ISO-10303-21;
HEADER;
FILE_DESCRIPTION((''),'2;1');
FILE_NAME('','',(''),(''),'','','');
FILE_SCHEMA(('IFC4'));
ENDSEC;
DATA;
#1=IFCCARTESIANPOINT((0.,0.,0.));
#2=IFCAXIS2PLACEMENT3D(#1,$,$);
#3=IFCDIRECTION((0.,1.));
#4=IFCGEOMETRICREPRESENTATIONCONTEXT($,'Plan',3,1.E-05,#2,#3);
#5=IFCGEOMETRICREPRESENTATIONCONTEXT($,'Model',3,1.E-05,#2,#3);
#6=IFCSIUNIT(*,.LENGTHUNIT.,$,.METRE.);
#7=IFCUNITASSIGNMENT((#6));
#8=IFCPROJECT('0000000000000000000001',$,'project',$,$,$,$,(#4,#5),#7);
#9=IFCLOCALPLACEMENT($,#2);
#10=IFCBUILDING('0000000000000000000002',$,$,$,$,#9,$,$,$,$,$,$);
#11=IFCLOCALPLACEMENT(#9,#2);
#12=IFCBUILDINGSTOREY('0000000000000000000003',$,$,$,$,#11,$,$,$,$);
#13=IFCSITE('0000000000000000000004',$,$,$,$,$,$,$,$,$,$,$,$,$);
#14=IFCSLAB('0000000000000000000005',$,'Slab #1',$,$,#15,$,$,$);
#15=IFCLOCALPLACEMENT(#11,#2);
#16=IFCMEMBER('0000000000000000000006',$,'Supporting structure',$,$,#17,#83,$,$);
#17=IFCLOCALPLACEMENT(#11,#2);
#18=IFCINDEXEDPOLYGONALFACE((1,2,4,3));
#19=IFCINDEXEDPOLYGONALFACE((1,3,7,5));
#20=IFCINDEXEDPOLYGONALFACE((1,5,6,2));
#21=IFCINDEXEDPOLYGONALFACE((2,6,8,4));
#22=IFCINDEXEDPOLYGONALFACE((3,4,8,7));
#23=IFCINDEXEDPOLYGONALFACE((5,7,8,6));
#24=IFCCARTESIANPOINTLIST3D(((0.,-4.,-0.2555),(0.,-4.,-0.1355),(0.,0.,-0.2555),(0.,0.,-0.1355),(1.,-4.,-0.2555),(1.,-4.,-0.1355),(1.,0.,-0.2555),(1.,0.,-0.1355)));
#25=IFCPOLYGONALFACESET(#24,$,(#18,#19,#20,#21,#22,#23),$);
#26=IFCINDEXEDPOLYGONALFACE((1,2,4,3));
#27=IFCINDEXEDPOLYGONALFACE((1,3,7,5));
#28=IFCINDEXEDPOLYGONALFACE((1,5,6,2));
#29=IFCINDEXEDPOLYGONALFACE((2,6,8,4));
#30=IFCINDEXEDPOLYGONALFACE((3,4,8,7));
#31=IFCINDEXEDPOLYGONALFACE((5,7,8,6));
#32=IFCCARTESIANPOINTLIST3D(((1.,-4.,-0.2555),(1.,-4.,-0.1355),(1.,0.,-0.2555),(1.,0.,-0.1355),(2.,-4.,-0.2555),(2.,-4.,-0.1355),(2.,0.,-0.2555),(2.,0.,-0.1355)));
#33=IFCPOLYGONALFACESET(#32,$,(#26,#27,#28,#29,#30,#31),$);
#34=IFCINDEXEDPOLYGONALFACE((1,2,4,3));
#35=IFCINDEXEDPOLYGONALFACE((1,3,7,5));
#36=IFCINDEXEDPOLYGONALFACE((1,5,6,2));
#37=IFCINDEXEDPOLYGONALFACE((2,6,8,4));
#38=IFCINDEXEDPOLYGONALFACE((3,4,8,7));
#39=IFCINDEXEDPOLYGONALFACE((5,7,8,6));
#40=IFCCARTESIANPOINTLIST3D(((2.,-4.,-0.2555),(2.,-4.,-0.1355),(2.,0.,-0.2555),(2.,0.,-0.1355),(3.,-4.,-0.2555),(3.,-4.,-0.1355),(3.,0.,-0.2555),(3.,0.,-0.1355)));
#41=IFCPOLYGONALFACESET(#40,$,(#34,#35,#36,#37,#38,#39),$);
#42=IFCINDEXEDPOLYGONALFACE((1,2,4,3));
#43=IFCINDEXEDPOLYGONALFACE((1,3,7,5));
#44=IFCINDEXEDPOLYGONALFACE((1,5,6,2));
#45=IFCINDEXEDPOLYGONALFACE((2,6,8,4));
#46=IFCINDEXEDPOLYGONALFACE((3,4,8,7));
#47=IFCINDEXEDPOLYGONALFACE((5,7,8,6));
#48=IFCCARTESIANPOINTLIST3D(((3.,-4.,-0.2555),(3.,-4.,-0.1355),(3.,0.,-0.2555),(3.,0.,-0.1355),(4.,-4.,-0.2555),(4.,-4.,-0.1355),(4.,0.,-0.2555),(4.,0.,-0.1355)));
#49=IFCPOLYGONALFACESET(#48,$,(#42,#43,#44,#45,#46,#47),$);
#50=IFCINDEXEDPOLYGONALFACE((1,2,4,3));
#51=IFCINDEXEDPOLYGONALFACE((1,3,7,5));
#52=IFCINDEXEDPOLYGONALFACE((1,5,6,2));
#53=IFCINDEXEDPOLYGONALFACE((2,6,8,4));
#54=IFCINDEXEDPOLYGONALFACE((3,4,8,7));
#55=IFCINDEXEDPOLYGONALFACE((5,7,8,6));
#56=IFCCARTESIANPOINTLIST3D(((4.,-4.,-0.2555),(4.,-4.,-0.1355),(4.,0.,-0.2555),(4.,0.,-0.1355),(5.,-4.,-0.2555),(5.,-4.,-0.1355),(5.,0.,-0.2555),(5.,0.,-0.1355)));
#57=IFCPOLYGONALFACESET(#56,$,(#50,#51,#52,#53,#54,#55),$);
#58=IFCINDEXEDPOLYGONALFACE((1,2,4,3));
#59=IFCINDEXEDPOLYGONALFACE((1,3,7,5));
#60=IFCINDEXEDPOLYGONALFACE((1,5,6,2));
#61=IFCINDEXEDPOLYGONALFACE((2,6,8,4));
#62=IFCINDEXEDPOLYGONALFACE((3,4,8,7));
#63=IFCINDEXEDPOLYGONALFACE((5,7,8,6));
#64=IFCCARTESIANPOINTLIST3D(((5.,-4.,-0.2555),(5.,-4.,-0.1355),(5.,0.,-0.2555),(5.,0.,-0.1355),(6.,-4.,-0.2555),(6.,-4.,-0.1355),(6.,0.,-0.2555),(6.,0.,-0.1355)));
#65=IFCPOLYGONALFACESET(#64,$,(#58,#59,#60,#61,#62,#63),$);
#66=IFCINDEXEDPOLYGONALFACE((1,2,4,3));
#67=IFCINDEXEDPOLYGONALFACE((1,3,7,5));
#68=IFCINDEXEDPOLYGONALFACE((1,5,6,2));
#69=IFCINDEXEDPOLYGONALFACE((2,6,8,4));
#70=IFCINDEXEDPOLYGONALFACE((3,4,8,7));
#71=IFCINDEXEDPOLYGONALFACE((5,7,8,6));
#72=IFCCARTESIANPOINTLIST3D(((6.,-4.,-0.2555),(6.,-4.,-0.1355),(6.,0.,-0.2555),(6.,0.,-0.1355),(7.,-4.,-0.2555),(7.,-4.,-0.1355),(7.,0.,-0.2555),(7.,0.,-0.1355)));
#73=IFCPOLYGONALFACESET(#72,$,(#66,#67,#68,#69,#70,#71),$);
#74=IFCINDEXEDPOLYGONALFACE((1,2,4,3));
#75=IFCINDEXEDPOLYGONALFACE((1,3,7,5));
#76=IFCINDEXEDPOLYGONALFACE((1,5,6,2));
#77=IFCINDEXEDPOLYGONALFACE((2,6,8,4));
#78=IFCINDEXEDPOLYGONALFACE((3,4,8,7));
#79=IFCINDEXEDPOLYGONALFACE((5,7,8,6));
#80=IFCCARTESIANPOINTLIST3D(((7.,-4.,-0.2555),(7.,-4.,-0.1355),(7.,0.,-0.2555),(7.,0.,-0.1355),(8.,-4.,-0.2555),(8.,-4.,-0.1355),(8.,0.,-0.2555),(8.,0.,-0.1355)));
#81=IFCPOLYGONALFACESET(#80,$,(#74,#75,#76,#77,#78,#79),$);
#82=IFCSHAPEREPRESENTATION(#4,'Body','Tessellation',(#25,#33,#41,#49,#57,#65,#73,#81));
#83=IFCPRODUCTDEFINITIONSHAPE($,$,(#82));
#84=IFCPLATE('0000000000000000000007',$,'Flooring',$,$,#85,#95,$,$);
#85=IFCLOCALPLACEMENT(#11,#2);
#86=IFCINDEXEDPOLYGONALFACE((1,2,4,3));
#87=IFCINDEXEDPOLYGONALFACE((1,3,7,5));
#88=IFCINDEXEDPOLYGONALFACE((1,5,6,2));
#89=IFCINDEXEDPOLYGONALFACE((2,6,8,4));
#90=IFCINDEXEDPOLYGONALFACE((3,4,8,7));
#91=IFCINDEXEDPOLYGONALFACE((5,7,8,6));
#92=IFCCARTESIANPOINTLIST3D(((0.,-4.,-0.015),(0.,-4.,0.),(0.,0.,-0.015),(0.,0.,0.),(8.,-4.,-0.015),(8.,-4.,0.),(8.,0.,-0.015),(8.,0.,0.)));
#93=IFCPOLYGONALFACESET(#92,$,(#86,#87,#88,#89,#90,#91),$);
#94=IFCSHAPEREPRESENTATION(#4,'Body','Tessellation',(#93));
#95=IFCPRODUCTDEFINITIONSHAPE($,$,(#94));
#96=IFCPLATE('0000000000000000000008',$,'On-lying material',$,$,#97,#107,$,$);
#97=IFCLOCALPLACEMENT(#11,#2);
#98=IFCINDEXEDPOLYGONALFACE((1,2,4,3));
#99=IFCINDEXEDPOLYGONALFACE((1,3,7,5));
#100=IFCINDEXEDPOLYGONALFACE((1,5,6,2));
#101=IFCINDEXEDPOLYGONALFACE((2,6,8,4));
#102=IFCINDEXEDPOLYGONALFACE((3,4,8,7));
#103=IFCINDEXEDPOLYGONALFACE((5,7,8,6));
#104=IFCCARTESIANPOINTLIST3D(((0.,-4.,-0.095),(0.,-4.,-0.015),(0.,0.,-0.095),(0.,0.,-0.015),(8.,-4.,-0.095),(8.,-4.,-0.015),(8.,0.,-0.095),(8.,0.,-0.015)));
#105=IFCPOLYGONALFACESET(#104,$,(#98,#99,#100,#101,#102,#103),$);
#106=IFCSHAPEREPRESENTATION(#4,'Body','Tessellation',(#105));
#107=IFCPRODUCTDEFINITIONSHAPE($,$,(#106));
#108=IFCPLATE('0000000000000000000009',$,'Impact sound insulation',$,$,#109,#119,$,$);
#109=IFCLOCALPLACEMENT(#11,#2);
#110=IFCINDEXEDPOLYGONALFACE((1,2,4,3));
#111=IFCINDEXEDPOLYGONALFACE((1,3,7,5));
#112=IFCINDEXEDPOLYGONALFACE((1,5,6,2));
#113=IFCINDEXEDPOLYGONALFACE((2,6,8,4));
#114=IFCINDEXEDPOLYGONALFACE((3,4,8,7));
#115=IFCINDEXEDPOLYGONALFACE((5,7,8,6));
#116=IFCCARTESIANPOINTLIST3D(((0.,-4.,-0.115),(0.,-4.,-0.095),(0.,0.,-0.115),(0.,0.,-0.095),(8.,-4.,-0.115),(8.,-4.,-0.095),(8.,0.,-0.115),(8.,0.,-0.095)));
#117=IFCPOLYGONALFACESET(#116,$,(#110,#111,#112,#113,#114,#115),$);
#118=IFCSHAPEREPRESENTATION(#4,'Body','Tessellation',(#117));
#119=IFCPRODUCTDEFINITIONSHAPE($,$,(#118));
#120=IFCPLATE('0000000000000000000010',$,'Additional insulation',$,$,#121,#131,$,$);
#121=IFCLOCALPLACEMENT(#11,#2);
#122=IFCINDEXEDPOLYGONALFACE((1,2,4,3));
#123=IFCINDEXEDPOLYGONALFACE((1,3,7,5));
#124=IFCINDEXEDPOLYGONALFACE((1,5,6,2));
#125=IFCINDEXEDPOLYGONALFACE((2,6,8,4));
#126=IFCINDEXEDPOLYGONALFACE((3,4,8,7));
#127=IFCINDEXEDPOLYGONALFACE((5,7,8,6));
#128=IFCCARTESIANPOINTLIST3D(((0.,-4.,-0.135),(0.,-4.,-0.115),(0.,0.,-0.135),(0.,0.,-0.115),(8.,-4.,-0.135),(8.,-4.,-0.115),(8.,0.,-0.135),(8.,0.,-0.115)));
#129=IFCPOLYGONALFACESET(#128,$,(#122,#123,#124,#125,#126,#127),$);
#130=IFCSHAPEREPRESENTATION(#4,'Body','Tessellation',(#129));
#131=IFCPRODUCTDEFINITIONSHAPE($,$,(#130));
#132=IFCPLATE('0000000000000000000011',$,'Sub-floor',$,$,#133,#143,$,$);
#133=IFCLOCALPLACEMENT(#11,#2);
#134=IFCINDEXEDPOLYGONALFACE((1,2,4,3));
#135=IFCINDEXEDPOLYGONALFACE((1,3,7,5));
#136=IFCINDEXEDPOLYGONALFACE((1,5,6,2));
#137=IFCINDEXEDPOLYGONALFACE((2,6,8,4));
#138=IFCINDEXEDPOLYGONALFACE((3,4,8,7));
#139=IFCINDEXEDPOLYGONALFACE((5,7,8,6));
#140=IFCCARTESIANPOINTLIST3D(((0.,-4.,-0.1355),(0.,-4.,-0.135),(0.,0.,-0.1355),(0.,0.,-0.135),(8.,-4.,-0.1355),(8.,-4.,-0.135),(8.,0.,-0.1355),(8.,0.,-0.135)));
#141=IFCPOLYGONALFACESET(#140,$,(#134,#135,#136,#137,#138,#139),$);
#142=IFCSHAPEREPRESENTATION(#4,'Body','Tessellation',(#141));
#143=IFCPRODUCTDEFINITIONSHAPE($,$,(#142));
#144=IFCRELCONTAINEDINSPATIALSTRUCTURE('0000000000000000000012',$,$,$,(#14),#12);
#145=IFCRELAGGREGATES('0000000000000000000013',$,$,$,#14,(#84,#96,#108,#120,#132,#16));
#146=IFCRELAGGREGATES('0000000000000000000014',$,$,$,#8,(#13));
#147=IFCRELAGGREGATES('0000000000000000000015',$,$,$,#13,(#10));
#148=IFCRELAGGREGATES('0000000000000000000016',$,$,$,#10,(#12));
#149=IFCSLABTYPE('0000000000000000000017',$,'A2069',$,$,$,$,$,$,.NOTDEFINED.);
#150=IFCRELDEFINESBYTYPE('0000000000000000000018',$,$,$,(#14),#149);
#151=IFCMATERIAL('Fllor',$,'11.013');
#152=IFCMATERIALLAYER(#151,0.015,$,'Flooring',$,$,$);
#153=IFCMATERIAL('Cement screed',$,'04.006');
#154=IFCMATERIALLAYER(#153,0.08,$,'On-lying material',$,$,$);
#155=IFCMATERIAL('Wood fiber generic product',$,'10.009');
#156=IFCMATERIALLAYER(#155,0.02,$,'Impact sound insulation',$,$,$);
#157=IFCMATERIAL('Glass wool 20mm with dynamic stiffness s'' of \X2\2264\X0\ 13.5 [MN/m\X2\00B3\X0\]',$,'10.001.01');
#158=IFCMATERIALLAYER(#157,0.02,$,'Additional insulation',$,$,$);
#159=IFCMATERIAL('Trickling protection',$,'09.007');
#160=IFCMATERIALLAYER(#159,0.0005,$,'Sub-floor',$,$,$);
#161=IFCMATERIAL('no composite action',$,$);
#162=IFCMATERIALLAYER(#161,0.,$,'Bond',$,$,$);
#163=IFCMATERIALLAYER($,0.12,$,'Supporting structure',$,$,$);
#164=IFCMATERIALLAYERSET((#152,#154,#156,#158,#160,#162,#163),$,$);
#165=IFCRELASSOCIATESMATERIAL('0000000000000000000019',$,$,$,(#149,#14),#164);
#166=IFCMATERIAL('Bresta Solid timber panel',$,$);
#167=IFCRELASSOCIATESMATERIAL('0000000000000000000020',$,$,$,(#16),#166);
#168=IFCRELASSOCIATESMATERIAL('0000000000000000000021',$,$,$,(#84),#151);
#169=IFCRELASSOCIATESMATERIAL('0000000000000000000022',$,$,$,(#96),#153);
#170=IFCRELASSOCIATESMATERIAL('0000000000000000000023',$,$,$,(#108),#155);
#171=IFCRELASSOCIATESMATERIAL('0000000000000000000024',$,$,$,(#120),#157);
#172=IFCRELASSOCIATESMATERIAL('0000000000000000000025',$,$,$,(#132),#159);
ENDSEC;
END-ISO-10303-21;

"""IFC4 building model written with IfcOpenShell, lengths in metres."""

from ifc_helpers import new_model, si_unit, direction, frame, frame_2d, origin, origin_with_axes, place, context, project, spatial, rectangle, extrude, material, layer, layer_set, type_object, element, aggregate, save


model = new_model("IFC4")

# Units and contexts
plan_context = context("Plan", 3, precision=1e-05, world=origin(), true_north=direction((0.0, 1.0)))
model_context = context("Model", 3, precision=1e-05, world=origin(), true_north=direction((0.0, 1.0)))
ifc_project = project(units=[si_unit("LENGTHUNIT", "METRE")], contexts=[plan_context, model_context])

# Site, building, storey
site = spatial("IfcSite", under=ifc_project)
building_placement = place(None, origin())
building = spatial("IfcBuilding", under=site, at=building_placement)
storey_placement = place(building_placement, origin())
storey = spatial("IfcBuildingStorey", under=building, at=storey_placement)

# Slab, member, plates
ifc_material_1 = material(Name="Fllor", Category="11.013")
ifc_layer_1 = layer(ifc_material_1, 0.015, Name="Flooring")
ifc_material_2 = material(Name="Cement screed", Category="04.006")
ifc_layer_2 = layer(ifc_material_2, 0.08, Name="On-lying material")
ifc_material_3 = material(Name="Wood fiber generic product", Category="10.009")
ifc_layer_3 = layer(ifc_material_3, 0.02, Name="Impact sound insulation")
ifc_material_4 = material(Name="Glass wool 20mm with dynamic stiffness s' of ≤ 13.5 [MN/m³]", Category="10.001.01")
ifc_layer_4 = layer(ifc_material_4, 0.02, Name="Additional insulation")
ifc_material_5 = material(Name="Trickling protection", Category="09.007")
ifc_layer_5 = layer(ifc_material_5, 0.0005, Name="Sub-floor")
ifc_material_6 = material(Name="no composite action")
ifc_layer_6 = layer(ifc_material_6, 0.0, Name="Bond")
ifc_layer_7 = layer(None, 0.12, Name="Supporting structure")
ifc_layer_set = layer_set([ifc_layer_1, ifc_layer_2, ifc_layer_3, ifc_layer_4, ifc_layer_5, ifc_layer_6, ifc_layer_7])
slab_type = type_object("IfcSlabType", Name="A2069", PredefinedType="NOTDEFINED", material=ifc_layer_set)
slab_placement = place(None, frame((0.0, 0.0, 0.0), z_axis=(0.0, 0.0, -1.0), x_axis=(1.0, 0.0, 0.0)))
slab = element("IfcSlab", 1, at=slab_placement, inside=storey, type_object=slab_type, material=ifc_layer_set, Name="Slab #1")
ifc_material_7 = material(Name="Bresta Solid timber panel")
member_placement = place(slab_placement, origin())
member = element("IfcMember", 2, at=member_placement, material=ifc_material_7, Name="Supporting structure", context=plan_context, shape_type="SweptSolid", body=[
    extrude(rectangle(XDim=1.0, YDim=0.12, at=frame_2d((0.5, 0.06), x_axis=(1.0, 0.0))), frame((0.0, 4.0, 0.1355), z_axis=(0.0, -1.0, 0.0), x_axis=(1.0, 0.0, 0.0)), (0.0, 0.0, 1.0), 4.0),
    extrude(rectangle(XDim=1.0, YDim=0.12, at=frame_2d((0.5, 0.06), x_axis=(1.0, 0.0))), frame((1.0, 4.0, 0.1355), z_axis=(0.0, -1.0, 0.0), x_axis=(1.0, 0.0, 0.0)), (0.0, 0.0, 1.0), 4.0),
    extrude(rectangle(XDim=1.0, YDim=0.12, at=frame_2d((0.5, 0.06), x_axis=(1.0, 0.0))), frame((2.0, 4.0, 0.1355), z_axis=(0.0, -1.0, 0.0), x_axis=(1.0, 0.0, 0.0)), (0.0, 0.0, 1.0), 4.0),
    extrude(rectangle(XDim=1.0, YDim=0.12, at=frame_2d((0.5, 0.06), x_axis=(1.0, 0.0))), frame((3.0, 4.0, 0.1355), z_axis=(0.0, -1.0, 0.0), x_axis=(1.0, 0.0, 0.0)), (0.0, 0.0, 1.0), 4.0),
    extrude(rectangle(XDim=1.0, YDim=0.12, at=frame_2d((0.5, 0.06), x_axis=(1.0, 0.0))), frame((4.0, 4.0, 0.1355), z_axis=(0.0, -1.0, 0.0), x_axis=(1.0, 0.0, 0.0)), (0.0, 0.0, 1.0), 4.0),
    extrude(rectangle(XDim=1.0, YDim=0.12, at=frame_2d((0.5, 0.06), x_axis=(1.0, 0.0))), frame((5.0, 4.0, 0.1355), z_axis=(0.0, -1.0, 0.0), x_axis=(1.0, 0.0, 0.0)), (0.0, 0.0, 1.0), 4.0),
    extrude(rectangle(XDim=1.0, YDim=0.12, at=frame_2d((0.5, 0.06), x_axis=(1.0, 0.0))), frame((6.0, 4.0, 0.1355), z_axis=(0.0, -1.0, 0.0), x_axis=(1.0, 0.0, 0.0)), (0.0, 0.0, 1.0), 4.0),
    extrude(rectangle(XDim=1.0, YDim=0.12, at=frame_2d((0.5, 0.06), x_axis=(1.0, 0.0))), frame((7.0, 4.0, 0.1355), z_axis=(0.0, -1.0, 0.0), x_axis=(1.0, 0.0, 0.0)), (0.0, 0.0, 1.0), 4.0),
])
plate_1_placement = place(slab_placement, origin())
plate_1 = element("IfcPlate", 3, at=plate_1_placement, material=ifc_material_1, Name="Flooring", context=plan_context, shape_type="SweptSolid", body=[
    extrude(rectangle(XDim=8.0, YDim=4.0, at=frame_2d((4.0, 2.0), x_axis=(1.0, 0.0))), origin_with_axes(), (0.0, 0.0, 1.0), 0.015),
])
plate_2_placement = place(slab_placement, origin())
plate_2 = element("IfcPlate", 4, at=plate_2_placement, material=ifc_material_2, Name="On-lying material", context=plan_context, shape_type="SweptSolid", body=[
    extrude(rectangle(XDim=8.0, YDim=4.0, at=frame_2d((4.0, 2.0), x_axis=(1.0, 0.0))), frame((0.0, 0.0, 0.015), z_axis=(0.0, 0.0, 1.0), x_axis=(1.0, 0.0, 0.0)), (0.0, 0.0, 1.0), 0.08),
])
plate_3_placement = place(slab_placement, origin())
plate_3 = element("IfcPlate", 5, at=plate_3_placement, material=ifc_material_3, Name="Impact sound insulation", context=plan_context, shape_type="SweptSolid", body=[
    extrude(rectangle(XDim=8.0, YDim=4.0, at=frame_2d((4.0, 2.0), x_axis=(1.0, 0.0))), frame((0.0, 0.0, 0.095), z_axis=(0.0, 0.0, 1.0), x_axis=(1.0, 0.0, 0.0)), (0.0, 0.0, 1.0), 0.02),
])
plate_4_placement = place(slab_placement, origin())
plate_4 = element("IfcPlate", 6, at=plate_4_placement, material=ifc_material_4, Name="Additional insulation", context=plan_context, shape_type="SweptSolid", body=[
    extrude(rectangle(XDim=8.0, YDim=4.0, at=frame_2d((4.0, 2.0), x_axis=(1.0, 0.0))), frame((0.0, 0.0, 0.115), z_axis=(0.0, 0.0, 1.0), x_axis=(1.0, 0.0, 0.0)), (0.0, 0.0, 1.0), 0.02),
])
plate_5_placement = place(slab_placement, origin())
plate_5 = element("IfcPlate", 7, at=plate_5_placement, material=ifc_material_5, Name="Sub-floor", context=plan_context, shape_type="SweptSolid", body=[
    extrude(rectangle(XDim=8.0, YDim=4.0, at=frame_2d((4.0, 2.0), x_axis=(1.0, 0.0))), frame((0.0, 0.0, 0.135), z_axis=(0.0, 0.0, 1.0), x_axis=(1.0, 0.0, 0.0)), (0.0, 0.0, 1.0), 0.0005),
])
aggregate(slab, [plate_1, plate_2, plate_3, plate_4, plate_5, member])

save(model, "model.ifc")
